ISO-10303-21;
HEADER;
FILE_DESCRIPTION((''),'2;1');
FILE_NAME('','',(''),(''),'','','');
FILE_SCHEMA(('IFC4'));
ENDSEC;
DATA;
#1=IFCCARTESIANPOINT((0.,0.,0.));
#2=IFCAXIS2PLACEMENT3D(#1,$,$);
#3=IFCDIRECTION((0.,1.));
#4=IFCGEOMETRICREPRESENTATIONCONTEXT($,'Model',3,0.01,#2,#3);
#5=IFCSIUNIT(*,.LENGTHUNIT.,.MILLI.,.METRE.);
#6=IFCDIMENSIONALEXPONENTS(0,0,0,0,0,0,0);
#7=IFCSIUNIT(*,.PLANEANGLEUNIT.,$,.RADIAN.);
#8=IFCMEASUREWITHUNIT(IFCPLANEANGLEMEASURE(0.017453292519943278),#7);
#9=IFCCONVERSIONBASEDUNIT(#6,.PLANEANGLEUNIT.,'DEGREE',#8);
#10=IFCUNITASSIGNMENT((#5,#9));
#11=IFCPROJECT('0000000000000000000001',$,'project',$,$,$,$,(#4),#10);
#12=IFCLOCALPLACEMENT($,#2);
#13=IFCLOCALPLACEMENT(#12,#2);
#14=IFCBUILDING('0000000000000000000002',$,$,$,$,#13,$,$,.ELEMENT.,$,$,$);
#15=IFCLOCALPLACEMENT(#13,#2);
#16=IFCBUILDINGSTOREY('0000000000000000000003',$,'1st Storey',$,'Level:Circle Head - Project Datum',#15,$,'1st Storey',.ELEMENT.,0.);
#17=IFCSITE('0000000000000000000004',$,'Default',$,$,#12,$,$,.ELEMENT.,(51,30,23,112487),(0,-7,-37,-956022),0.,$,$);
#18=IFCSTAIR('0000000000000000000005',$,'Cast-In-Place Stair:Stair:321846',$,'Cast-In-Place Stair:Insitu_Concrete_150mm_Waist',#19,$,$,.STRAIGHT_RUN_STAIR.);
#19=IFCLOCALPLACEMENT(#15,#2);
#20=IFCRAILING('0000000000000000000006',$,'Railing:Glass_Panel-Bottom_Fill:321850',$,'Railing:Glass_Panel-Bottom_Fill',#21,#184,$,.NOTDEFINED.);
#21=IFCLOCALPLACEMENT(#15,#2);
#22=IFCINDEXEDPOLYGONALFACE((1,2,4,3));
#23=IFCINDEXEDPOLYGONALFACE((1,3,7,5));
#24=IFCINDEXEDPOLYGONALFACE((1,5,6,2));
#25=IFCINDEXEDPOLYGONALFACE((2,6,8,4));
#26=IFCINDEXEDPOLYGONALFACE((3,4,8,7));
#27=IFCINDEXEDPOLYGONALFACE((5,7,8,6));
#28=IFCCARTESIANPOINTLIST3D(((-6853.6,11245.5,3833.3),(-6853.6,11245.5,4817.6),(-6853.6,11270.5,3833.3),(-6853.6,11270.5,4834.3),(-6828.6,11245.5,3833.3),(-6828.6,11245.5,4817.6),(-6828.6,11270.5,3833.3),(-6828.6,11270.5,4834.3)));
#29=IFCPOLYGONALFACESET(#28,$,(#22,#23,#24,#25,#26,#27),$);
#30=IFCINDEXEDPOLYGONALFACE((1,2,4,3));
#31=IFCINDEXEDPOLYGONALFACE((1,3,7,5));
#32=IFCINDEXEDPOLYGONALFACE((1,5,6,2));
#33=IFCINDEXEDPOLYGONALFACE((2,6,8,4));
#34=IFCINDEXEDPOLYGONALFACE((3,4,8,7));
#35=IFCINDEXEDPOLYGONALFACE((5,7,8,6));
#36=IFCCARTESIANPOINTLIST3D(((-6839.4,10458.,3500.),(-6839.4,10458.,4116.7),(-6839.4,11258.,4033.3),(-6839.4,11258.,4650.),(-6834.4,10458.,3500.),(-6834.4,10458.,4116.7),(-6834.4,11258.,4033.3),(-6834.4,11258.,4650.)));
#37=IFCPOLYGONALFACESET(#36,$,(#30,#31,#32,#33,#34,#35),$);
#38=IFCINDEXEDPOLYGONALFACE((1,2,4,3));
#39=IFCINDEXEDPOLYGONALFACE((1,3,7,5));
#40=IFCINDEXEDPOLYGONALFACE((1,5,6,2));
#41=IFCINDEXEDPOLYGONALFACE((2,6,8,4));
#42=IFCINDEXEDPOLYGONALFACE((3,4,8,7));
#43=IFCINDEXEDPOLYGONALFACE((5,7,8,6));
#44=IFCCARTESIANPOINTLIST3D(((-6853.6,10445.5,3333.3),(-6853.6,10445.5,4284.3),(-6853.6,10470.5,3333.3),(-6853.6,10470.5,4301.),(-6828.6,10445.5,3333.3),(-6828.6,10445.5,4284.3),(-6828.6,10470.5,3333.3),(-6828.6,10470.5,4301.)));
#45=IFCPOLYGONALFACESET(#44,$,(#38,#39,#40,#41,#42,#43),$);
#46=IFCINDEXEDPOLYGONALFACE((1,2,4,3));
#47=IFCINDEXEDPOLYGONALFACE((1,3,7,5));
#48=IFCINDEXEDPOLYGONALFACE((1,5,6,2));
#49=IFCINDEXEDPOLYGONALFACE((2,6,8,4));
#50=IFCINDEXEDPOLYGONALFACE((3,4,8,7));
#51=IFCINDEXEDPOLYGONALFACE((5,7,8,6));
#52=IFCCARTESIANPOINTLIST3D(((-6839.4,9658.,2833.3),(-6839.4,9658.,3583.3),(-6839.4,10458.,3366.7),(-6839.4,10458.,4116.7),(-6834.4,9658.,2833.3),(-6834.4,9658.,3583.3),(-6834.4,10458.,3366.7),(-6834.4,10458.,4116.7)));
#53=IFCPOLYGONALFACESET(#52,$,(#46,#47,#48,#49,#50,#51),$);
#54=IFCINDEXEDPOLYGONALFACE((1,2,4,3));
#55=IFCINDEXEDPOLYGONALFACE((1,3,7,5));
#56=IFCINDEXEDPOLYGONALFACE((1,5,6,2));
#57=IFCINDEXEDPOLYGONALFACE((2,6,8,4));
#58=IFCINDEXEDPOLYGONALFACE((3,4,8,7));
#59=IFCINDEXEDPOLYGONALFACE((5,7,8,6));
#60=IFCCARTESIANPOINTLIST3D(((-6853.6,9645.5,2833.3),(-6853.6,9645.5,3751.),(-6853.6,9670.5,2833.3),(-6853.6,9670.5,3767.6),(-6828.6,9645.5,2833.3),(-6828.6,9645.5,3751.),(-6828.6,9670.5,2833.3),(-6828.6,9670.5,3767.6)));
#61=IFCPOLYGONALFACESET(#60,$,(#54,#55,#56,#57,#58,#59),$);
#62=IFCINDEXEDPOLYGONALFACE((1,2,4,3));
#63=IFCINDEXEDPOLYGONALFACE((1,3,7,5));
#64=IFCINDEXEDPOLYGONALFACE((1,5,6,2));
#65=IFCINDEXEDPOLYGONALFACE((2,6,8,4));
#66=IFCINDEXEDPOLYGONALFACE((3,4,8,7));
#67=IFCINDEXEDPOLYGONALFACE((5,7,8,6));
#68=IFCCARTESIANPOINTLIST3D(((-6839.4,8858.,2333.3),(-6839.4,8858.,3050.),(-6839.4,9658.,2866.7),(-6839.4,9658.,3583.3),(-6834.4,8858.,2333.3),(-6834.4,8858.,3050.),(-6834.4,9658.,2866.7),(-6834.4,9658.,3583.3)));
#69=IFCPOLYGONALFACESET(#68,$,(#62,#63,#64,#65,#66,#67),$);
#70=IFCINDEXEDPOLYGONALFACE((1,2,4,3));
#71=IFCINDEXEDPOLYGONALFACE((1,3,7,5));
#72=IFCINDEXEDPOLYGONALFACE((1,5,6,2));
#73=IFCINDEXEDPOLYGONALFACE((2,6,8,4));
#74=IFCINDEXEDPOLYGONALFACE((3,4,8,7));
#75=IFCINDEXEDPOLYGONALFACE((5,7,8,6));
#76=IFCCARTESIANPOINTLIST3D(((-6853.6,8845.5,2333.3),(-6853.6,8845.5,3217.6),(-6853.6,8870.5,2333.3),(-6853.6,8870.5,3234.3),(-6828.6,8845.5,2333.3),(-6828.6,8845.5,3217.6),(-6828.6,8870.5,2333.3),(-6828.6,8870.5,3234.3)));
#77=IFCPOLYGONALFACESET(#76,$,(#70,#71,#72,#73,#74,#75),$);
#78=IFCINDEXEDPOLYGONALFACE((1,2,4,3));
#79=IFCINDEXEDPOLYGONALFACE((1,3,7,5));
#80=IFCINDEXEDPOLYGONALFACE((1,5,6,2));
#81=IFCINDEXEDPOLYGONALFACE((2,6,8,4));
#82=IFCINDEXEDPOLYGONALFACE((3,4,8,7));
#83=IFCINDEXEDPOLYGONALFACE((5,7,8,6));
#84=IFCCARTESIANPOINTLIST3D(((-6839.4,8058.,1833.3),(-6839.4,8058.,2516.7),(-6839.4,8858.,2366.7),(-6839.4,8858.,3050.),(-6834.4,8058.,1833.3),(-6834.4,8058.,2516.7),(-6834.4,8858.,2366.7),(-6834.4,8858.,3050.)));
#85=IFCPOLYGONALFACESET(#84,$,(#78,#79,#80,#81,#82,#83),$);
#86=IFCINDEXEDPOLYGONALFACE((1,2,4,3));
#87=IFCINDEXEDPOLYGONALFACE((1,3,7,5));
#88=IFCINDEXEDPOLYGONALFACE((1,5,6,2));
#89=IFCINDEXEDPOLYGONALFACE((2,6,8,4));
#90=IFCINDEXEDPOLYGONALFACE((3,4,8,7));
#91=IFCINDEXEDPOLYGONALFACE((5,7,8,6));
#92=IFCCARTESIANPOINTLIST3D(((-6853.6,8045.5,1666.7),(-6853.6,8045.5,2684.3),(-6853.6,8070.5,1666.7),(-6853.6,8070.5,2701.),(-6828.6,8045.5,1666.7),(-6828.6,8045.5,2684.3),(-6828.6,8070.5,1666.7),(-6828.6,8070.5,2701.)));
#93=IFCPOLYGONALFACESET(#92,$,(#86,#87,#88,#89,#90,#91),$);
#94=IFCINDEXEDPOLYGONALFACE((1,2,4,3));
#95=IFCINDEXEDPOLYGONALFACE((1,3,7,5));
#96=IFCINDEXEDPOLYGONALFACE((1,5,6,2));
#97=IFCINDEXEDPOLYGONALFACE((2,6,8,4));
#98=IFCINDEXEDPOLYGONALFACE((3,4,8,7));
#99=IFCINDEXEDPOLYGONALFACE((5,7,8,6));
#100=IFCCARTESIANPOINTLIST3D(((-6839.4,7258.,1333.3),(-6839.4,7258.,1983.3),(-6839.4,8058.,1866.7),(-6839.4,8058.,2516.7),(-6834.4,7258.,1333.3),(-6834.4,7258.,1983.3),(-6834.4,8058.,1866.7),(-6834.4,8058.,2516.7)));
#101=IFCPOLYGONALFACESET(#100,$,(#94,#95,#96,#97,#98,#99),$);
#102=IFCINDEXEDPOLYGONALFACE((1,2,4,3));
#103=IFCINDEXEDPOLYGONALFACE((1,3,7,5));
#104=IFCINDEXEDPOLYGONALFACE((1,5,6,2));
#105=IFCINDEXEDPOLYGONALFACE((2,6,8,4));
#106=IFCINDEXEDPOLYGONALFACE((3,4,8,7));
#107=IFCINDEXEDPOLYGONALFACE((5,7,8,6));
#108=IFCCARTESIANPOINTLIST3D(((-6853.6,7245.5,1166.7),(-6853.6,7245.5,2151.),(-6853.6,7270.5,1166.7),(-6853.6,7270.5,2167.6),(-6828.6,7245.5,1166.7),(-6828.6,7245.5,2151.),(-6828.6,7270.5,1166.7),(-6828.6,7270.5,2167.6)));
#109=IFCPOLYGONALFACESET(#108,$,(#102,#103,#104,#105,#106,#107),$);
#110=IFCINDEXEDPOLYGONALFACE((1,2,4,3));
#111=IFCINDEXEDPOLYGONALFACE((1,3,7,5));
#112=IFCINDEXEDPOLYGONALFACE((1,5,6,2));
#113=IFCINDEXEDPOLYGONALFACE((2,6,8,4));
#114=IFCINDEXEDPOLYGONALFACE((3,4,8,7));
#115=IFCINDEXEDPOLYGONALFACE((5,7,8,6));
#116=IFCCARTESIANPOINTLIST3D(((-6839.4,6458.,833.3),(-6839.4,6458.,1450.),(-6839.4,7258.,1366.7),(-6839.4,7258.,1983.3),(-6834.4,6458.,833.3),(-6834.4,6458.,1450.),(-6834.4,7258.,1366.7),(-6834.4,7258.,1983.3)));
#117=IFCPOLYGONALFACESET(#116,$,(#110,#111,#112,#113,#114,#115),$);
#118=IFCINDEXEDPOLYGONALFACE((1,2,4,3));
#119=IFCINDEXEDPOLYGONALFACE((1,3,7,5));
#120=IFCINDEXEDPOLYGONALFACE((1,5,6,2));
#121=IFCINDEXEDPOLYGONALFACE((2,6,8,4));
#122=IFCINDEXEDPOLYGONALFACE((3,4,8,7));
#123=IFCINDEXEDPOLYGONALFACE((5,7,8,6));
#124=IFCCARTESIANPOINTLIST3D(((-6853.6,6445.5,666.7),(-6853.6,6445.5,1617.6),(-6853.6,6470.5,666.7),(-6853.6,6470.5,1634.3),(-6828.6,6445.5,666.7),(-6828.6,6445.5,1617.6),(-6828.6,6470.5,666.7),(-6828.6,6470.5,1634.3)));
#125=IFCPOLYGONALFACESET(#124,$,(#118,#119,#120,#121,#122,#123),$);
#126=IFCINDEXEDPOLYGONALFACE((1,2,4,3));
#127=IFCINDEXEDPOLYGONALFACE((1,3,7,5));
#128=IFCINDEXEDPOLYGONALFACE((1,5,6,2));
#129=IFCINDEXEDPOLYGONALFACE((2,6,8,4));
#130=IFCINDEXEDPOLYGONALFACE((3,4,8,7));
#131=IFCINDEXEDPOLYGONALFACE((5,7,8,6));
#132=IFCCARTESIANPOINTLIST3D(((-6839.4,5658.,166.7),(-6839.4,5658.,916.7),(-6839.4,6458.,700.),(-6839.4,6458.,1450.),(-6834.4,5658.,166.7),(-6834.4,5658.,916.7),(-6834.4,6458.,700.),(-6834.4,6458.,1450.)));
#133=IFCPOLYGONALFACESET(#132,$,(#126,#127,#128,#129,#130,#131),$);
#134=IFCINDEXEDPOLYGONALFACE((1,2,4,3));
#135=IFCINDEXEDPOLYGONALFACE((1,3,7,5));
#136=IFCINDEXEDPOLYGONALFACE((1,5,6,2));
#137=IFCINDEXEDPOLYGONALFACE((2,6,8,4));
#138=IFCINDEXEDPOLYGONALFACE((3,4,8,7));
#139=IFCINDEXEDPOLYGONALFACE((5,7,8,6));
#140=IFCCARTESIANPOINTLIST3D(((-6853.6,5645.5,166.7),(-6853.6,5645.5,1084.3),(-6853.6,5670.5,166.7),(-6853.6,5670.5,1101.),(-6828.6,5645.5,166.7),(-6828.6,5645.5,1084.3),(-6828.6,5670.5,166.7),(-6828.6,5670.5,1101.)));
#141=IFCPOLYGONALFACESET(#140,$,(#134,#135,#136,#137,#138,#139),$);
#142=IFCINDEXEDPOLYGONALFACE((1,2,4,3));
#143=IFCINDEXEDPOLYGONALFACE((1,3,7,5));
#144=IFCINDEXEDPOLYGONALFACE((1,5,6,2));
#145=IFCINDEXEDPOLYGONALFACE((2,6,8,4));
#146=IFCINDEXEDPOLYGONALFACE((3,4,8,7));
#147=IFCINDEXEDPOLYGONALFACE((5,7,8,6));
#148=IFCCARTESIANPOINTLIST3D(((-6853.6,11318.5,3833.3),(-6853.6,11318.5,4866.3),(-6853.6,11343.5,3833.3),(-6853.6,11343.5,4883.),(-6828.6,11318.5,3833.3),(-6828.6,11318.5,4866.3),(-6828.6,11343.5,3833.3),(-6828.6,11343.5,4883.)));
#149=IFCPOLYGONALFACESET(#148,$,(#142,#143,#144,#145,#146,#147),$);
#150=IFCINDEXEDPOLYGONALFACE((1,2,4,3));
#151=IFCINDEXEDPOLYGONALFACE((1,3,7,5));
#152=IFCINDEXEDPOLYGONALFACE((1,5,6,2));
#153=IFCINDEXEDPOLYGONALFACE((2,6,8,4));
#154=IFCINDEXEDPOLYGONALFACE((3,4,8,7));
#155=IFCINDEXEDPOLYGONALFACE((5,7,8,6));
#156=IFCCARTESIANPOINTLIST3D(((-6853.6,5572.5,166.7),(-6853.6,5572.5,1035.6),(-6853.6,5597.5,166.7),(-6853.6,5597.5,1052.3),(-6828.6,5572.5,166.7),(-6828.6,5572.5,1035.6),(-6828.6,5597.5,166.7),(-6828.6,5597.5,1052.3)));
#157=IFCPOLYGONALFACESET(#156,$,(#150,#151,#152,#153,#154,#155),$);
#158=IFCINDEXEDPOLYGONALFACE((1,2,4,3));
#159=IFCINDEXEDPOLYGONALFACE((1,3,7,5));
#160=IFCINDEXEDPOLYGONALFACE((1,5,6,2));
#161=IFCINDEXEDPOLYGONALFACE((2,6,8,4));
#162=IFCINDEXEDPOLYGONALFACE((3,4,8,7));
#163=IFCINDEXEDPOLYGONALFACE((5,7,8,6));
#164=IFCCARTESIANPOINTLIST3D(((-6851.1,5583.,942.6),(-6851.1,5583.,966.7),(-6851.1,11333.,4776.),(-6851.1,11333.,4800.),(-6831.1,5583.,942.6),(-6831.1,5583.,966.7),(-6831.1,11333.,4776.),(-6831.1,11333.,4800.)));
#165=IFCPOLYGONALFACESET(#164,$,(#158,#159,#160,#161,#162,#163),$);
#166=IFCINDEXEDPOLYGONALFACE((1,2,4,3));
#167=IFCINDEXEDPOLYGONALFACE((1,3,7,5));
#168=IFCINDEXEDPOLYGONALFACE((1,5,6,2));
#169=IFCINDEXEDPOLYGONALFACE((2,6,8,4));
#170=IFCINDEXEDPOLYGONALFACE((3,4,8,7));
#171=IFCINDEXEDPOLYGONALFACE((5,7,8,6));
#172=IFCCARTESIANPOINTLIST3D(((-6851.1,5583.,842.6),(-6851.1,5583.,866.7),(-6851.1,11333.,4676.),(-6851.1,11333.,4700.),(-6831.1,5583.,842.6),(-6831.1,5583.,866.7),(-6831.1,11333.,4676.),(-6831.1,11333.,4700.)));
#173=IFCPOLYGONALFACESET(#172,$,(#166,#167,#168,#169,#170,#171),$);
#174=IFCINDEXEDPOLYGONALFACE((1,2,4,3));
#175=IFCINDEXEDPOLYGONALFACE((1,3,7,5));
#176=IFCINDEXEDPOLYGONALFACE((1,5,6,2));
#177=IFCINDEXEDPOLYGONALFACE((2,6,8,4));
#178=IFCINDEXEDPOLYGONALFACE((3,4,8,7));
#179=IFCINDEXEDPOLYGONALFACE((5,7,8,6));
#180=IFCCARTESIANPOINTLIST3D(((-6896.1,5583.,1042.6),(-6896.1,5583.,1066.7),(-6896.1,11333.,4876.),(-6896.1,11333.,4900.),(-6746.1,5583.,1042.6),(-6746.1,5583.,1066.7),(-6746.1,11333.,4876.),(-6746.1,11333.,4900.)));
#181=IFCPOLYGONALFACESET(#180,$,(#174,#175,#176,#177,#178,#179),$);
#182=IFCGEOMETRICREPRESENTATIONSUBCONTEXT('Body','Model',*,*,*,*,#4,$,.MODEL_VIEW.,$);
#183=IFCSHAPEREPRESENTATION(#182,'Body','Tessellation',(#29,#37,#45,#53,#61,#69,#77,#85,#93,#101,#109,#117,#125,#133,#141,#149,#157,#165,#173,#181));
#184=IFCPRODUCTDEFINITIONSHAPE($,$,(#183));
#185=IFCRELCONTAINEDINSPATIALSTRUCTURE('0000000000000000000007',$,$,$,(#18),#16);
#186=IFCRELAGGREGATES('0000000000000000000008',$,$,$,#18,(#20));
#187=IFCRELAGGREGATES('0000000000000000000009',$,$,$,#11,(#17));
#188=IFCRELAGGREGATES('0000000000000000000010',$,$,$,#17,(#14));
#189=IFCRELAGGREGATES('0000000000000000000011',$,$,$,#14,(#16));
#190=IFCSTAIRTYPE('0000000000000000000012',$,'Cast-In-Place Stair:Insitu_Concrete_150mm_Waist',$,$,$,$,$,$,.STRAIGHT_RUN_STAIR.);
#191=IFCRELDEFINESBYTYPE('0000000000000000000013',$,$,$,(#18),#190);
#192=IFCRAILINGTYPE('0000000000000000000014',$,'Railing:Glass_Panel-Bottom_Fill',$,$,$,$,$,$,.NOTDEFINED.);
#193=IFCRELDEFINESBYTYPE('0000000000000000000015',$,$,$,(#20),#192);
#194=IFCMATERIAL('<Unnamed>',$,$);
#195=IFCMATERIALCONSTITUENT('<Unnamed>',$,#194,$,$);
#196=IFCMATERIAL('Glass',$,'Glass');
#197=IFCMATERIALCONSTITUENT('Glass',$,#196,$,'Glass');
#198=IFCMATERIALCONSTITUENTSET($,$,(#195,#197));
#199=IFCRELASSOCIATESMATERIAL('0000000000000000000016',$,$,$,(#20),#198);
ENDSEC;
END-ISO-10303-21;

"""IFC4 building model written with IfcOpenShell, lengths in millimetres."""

from ifc_helpers import new_model, entity, si_unit, converted_unit, direction, frame, origin, place, context, subcontext, project, spatial, indexed_curve, outline, extrude, material, constituent, constituent_set, type_object, element, aggregate, save


model = new_model("IFC4")

# Units and contexts
model_context = context("Model", 3, precision=0.01, world=origin(), true_north=direction((0.0, 1.0)))
body_context = subcontext(model_context, "Body", "Model", "MODEL_VIEW")
ifc_project = project(units=[si_unit("LENGTHUNIT", "METRE", prefix="MILLI"), converted_unit("PLANEANGLEUNIT", "DEGREE", entity("IfcPlaneAngleMeasure", 0.017453292519943278), si_unit("PLANEANGLEUNIT", "RADIAN"), dimensions=[0, 0, 0, 0, 0, 0, 0])], contexts=[model_context])

# Site, building, storey
site_placement = place(None, origin())
site = spatial("IfcSite", under=ifc_project, at=site_placement, Name="Default", CompositionType="ELEMENT", RefLatitude=(51, 30, 23, 112487), RefLongitude=(0, -7, -37, -956022), RefElevation=0.0)
building_placement = place(site_placement, origin())
building = spatial("IfcBuilding", under=site, at=building_placement, CompositionType="ELEMENT")
storey_placement = place(building_placement, origin())
storey = spatial("IfcBuildingStorey", under=building, at=storey_placement, Name="1st Storey", ObjectType="Level:Circle Head - Project Datum", LongName="1st Storey", CompositionType="ELEMENT", Elevation=0.0)

# Shared definitions
ifc_material_1 = material(Name="<Unnamed>")

# Stair, railing
stair_type_1 = type_object("IfcStairType", Name="Cast-In-Place Stair:Insitu_Concrete_150mm_Waist", PredefinedType="STRAIGHT_RUN_STAIR")
stair_1_placement = place(storey_placement, origin())
stair_1 = element("IfcStair", 1, at=stair_1_placement, inside=storey, type_object=stair_type_1, Name="Cast-In-Place Stair:Stair:321846", ObjectType="Cast-In-Place Stair:Insitu_Concrete_150mm_Waist", PredefinedType="STRAIGHT_RUN_STAIR")
ifc_constituent_1 = constituent(ifc_material_1, Name="<Unnamed>")
ifc_material_2 = material(Name="Glass", Category="Glass")
ifc_constituent_2 = constituent(ifc_material_2, Name="Glass", Category="Glass")
ifc_constituent_set = constituent_set(constituents=[ifc_constituent_1, ifc_constituent_2])
railing_type = type_object("IfcRailingType", Name="Railing:Glass_Panel-Bottom_Fill", PredefinedType="NOTDEFINED")
railing_placement = place(stair_1_placement, frame((-6896.1, 5572.5, 166.7)))
railing = element("IfcRailing", 2, at=railing_placement, type_object=railing_type, material=ifc_constituent_set, Name="Railing:Glass_Panel-Bottom_Fill:321850", ObjectType="Railing:Glass_Panel-Bottom_Fill", PredefinedType="NOTDEFINED", context=body_context, shape_type="SweptSolid", body=[
    extrude(outline(indexed_curve([(-12.5, -496.3), (12.5, -496.3), (12.5, 504.6), (-12.5, 488.0), (-12.5, -496.3)], self_intersect=False)), frame((42.5, 5685.5, 4163.0), z_axis=(1.0, 0.0, 0.0), x_axis=(0.0, 1.0, 0.0)), (0.0, 0.0, 1.0), 25.0),
    extrude(outline(indexed_curve([(-41.7, -400.0), (575.0, -400.0), (41.7, 400.0), (-575.0, 400.0), (-41.7, -400.0)], self_intersect=False)), frame((56.7, 5285.5, 3908.3), z_axis=(1.0, 0.0, 0.0), x_axis=(0.0, 0.0, -1.0)), (0.0, 0.0, 1.0), 5.0),
    extrude(outline(indexed_curve([(-12.5, -479.6), (12.5, -479.6), (12.5, 488.0), (-12.5, 471.3), (-12.5, -479.6)], self_intersect=False)), frame((42.5, 4885.5, 3646.3), z_axis=(1.0, 0.0, 0.0), x_axis=(0.0, 1.0, 0.0)), (0.0, 0.0, 1.0), 25.0),
    extrude(outline(indexed_curve([(-108.3, -400.0), (641.7, -400.0), (108.3, 400.0), (-641.7, 400.0), (-108.3, -400.0)], self_intersect=False)), frame((56.7, 4485.5, 3308.3), z_axis=(1.0, 0.0, 0.0), x_axis=(0.0, 0.0, -1.0)), (0.0, 0.0, 1.0), 5.0),
    extrude(outline(indexed_curve([(-12.5, -463.0), (12.5, -463.0), (12.5, 471.3), (-12.5, 454.6), (-12.5, -463.0)], self_intersect=False)), frame((42.5, 4085.5, 3129.6), z_axis=(1.0, 0.0, 0.0), x_axis=(0.0, 1.0, 0.0)), (0.0, 0.0, 1.0), 25.0),
    extrude(outline(indexed_curve([(-91.7, -400.0), (625.0, -400.0), (91.7, 400.0), (-625.0, 400.0), (-91.7, -400.0)], self_intersect=False)), frame((56.7, 3685.5, 2791.7), z_axis=(1.0, 0.0, 0.0), x_axis=(0.0, 0.0, -1.0)), (0.0, 0.0, 1.0), 5.0),
    extrude(outline(indexed_curve([(-12.5, -446.3), (12.5, -446.3), (12.5, 454.6), (-12.5, 438.0), (-12.5, -446.3)], self_intersect=False)), frame((42.5, 3285.5, 2613.0), z_axis=(1.0, 0.0, 0.0), x_axis=(0.0, 1.0, 0.0)), (0.0, 0.0, 1.0), 25.0),
    extrude(outline(indexed_curve([(-75.0, -400.0), (608.3, -400.0), (75.0, 400.0), (-608.3, 400.0), (-75.0, -400.0)], self_intersect=False)), frame((56.7, 2885.5, 2275.0), z_axis=(1.0, 0.0, 0.0), x_axis=(0.0, 0.0, -1.0)), (0.0, 0.0, 1.0), 5.0),
    extrude(outline(indexed_curve([(-12.5, -513.0), (12.5, -513.0), (12.5, 521.3), (-12.5, 504.6), (-12.5, -513.0)], self_intersect=False)), frame((42.5, 2485.5, 2013.0), z_axis=(1.0, 0.0, 0.0), x_axis=(0.0, 1.0, 0.0)), (0.0, 0.0, 1.0), 25.0),
    extrude(outline(indexed_curve([(-58.3, -400.0), (591.7, -400.0), (58.3, 400.0), (-591.7, 400.0), (-58.3, -400.0)], self_intersect=False)), frame((56.7, 2085.5, 1758.3), z_axis=(1.0, 0.0, 0.0), x_axis=(0.0, 0.0, -1.0)), (0.0, 0.0, 1.0), 5.0),
    extrude(outline(indexed_curve([(-12.5, -496.3), (12.5, -496.3), (12.5, 504.6), (-12.5, 488.0), (-12.5, -496.3)], self_intersect=False)), frame((42.5, 1685.5, 1496.3), z_axis=(1.0, 0.0, 0.0), x_axis=(0.0, 1.0, 0.0)), (0.0, 0.0, 1.0), 25.0),
    extrude(outline(indexed_curve([(-41.7, -400.0), (575.0, -400.0), (41.7, 400.0), (-575.0, 400.0), (-41.7, -400.0)], self_intersect=False)), frame((56.7, 1285.5, 1241.7), z_axis=(1.0, 0.0, 0.0), x_axis=(0.0, 0.0, -1.0)), (0.0, 0.0, 1.0), 5.0),
    extrude(outline(indexed_curve([(-12.5, -479.6), (12.5, -479.6), (12.5, 488.0), (-12.5, 471.3), (-12.5, -479.6)], self_intersect=False)), frame((42.5, 885.5, 979.6), z_axis=(1.0, 0.0, 0.0), x_axis=(0.0, 1.0, 0.0)), (0.0, 0.0, 1.0), 25.0),
    extrude(outline(indexed_curve([(-108.3, -400.0), (641.7, -400.0), (108.3, 400.0), (-641.7, 400.0), (-108.3, -400.0)], self_intersect=False)), frame((56.7, 485.5, 641.7), z_axis=(1.0, 0.0, 0.0), x_axis=(0.0, 0.0, -1.0)), (0.0, 0.0, 1.0), 5.0),
    extrude(outline(indexed_curve([(-12.5, -463.0), (12.5, -463.0), (12.5, 471.3), (-12.5, 454.6), (-12.5, -463.0)], self_intersect=False)), frame((42.5, 85.5, 463.0), z_axis=(1.0, 0.0, 0.0), x_axis=(0.0, 1.0, 0.0)), (0.0, 0.0, 1.0), 25.0),
    extrude(outline(indexed_curve([(-12.5, -520.6), (12.5, -520.6), (12.5, 529.0), (-12.5, 512.3), (-12.5, -520.6)], self_intersect=False)), frame((42.5, 5758.5, 4187.3), z_axis=(1.0, 0.0, 0.0), x_axis=(0.0, 1.0, 0.0)), (0.0, 0.0, 1.0), 25.0),
    extrude(outline(indexed_curve([(-12.5, -438.6), (12.5, -438.6), (12.5, 447.0), (-12.5, 430.3), (-12.5, -438.6)], self_intersect=False)), frame((42.5, 12.5, 438.6), z_axis=(1.0, 0.0, 0.0), x_axis=(0.0, 1.0, 0.0)), (0.0, 0.0, 1.0), 25.0),
    extrude(outline(indexed_curve([(-3462.0, -10.0), (3448.7, -10.0), (3462.0, 10.0), (-3448.7, 10.0), (-3462.0, -10.0)], self_intersect=False)), frame((45.0, 2885.5, 2704.6), z_axis=(1.0, 0.0, 0.0), x_axis=(0.0, 0.83205, 0.5547)), (0.0, 0.0, 1.0), 20.0),
    extrude(outline(indexed_curve([(-3462.0, -10.0), (3448.7, -10.0), (3462.0, 10.0), (-3448.7, 10.0), (-3462.0, -10.0)], self_intersect=False)), frame((45.0, 2885.5, 2604.6), z_axis=(1.0, 0.0, 0.0), x_axis=(0.0, 0.83205, 0.5547)), (0.0, 0.0, 1.0), 20.0),
    extrude(outline(indexed_curve([(-3462.0, -10.0), (3448.7, -10.0), (3462.0, 10.0), (-3448.7, 10.0), (-3462.0, -10.0)], self_intersect=False)), frame((0.0, 2885.5, 2804.6), z_axis=(1.0, 0.0, 0.0), x_axis=(0.0, 0.83205, 0.5547)), (0.0, 0.0, 1.0), 150.0),
])
aggregate(stair_1, [railing])

save(model, "model.ifc")
